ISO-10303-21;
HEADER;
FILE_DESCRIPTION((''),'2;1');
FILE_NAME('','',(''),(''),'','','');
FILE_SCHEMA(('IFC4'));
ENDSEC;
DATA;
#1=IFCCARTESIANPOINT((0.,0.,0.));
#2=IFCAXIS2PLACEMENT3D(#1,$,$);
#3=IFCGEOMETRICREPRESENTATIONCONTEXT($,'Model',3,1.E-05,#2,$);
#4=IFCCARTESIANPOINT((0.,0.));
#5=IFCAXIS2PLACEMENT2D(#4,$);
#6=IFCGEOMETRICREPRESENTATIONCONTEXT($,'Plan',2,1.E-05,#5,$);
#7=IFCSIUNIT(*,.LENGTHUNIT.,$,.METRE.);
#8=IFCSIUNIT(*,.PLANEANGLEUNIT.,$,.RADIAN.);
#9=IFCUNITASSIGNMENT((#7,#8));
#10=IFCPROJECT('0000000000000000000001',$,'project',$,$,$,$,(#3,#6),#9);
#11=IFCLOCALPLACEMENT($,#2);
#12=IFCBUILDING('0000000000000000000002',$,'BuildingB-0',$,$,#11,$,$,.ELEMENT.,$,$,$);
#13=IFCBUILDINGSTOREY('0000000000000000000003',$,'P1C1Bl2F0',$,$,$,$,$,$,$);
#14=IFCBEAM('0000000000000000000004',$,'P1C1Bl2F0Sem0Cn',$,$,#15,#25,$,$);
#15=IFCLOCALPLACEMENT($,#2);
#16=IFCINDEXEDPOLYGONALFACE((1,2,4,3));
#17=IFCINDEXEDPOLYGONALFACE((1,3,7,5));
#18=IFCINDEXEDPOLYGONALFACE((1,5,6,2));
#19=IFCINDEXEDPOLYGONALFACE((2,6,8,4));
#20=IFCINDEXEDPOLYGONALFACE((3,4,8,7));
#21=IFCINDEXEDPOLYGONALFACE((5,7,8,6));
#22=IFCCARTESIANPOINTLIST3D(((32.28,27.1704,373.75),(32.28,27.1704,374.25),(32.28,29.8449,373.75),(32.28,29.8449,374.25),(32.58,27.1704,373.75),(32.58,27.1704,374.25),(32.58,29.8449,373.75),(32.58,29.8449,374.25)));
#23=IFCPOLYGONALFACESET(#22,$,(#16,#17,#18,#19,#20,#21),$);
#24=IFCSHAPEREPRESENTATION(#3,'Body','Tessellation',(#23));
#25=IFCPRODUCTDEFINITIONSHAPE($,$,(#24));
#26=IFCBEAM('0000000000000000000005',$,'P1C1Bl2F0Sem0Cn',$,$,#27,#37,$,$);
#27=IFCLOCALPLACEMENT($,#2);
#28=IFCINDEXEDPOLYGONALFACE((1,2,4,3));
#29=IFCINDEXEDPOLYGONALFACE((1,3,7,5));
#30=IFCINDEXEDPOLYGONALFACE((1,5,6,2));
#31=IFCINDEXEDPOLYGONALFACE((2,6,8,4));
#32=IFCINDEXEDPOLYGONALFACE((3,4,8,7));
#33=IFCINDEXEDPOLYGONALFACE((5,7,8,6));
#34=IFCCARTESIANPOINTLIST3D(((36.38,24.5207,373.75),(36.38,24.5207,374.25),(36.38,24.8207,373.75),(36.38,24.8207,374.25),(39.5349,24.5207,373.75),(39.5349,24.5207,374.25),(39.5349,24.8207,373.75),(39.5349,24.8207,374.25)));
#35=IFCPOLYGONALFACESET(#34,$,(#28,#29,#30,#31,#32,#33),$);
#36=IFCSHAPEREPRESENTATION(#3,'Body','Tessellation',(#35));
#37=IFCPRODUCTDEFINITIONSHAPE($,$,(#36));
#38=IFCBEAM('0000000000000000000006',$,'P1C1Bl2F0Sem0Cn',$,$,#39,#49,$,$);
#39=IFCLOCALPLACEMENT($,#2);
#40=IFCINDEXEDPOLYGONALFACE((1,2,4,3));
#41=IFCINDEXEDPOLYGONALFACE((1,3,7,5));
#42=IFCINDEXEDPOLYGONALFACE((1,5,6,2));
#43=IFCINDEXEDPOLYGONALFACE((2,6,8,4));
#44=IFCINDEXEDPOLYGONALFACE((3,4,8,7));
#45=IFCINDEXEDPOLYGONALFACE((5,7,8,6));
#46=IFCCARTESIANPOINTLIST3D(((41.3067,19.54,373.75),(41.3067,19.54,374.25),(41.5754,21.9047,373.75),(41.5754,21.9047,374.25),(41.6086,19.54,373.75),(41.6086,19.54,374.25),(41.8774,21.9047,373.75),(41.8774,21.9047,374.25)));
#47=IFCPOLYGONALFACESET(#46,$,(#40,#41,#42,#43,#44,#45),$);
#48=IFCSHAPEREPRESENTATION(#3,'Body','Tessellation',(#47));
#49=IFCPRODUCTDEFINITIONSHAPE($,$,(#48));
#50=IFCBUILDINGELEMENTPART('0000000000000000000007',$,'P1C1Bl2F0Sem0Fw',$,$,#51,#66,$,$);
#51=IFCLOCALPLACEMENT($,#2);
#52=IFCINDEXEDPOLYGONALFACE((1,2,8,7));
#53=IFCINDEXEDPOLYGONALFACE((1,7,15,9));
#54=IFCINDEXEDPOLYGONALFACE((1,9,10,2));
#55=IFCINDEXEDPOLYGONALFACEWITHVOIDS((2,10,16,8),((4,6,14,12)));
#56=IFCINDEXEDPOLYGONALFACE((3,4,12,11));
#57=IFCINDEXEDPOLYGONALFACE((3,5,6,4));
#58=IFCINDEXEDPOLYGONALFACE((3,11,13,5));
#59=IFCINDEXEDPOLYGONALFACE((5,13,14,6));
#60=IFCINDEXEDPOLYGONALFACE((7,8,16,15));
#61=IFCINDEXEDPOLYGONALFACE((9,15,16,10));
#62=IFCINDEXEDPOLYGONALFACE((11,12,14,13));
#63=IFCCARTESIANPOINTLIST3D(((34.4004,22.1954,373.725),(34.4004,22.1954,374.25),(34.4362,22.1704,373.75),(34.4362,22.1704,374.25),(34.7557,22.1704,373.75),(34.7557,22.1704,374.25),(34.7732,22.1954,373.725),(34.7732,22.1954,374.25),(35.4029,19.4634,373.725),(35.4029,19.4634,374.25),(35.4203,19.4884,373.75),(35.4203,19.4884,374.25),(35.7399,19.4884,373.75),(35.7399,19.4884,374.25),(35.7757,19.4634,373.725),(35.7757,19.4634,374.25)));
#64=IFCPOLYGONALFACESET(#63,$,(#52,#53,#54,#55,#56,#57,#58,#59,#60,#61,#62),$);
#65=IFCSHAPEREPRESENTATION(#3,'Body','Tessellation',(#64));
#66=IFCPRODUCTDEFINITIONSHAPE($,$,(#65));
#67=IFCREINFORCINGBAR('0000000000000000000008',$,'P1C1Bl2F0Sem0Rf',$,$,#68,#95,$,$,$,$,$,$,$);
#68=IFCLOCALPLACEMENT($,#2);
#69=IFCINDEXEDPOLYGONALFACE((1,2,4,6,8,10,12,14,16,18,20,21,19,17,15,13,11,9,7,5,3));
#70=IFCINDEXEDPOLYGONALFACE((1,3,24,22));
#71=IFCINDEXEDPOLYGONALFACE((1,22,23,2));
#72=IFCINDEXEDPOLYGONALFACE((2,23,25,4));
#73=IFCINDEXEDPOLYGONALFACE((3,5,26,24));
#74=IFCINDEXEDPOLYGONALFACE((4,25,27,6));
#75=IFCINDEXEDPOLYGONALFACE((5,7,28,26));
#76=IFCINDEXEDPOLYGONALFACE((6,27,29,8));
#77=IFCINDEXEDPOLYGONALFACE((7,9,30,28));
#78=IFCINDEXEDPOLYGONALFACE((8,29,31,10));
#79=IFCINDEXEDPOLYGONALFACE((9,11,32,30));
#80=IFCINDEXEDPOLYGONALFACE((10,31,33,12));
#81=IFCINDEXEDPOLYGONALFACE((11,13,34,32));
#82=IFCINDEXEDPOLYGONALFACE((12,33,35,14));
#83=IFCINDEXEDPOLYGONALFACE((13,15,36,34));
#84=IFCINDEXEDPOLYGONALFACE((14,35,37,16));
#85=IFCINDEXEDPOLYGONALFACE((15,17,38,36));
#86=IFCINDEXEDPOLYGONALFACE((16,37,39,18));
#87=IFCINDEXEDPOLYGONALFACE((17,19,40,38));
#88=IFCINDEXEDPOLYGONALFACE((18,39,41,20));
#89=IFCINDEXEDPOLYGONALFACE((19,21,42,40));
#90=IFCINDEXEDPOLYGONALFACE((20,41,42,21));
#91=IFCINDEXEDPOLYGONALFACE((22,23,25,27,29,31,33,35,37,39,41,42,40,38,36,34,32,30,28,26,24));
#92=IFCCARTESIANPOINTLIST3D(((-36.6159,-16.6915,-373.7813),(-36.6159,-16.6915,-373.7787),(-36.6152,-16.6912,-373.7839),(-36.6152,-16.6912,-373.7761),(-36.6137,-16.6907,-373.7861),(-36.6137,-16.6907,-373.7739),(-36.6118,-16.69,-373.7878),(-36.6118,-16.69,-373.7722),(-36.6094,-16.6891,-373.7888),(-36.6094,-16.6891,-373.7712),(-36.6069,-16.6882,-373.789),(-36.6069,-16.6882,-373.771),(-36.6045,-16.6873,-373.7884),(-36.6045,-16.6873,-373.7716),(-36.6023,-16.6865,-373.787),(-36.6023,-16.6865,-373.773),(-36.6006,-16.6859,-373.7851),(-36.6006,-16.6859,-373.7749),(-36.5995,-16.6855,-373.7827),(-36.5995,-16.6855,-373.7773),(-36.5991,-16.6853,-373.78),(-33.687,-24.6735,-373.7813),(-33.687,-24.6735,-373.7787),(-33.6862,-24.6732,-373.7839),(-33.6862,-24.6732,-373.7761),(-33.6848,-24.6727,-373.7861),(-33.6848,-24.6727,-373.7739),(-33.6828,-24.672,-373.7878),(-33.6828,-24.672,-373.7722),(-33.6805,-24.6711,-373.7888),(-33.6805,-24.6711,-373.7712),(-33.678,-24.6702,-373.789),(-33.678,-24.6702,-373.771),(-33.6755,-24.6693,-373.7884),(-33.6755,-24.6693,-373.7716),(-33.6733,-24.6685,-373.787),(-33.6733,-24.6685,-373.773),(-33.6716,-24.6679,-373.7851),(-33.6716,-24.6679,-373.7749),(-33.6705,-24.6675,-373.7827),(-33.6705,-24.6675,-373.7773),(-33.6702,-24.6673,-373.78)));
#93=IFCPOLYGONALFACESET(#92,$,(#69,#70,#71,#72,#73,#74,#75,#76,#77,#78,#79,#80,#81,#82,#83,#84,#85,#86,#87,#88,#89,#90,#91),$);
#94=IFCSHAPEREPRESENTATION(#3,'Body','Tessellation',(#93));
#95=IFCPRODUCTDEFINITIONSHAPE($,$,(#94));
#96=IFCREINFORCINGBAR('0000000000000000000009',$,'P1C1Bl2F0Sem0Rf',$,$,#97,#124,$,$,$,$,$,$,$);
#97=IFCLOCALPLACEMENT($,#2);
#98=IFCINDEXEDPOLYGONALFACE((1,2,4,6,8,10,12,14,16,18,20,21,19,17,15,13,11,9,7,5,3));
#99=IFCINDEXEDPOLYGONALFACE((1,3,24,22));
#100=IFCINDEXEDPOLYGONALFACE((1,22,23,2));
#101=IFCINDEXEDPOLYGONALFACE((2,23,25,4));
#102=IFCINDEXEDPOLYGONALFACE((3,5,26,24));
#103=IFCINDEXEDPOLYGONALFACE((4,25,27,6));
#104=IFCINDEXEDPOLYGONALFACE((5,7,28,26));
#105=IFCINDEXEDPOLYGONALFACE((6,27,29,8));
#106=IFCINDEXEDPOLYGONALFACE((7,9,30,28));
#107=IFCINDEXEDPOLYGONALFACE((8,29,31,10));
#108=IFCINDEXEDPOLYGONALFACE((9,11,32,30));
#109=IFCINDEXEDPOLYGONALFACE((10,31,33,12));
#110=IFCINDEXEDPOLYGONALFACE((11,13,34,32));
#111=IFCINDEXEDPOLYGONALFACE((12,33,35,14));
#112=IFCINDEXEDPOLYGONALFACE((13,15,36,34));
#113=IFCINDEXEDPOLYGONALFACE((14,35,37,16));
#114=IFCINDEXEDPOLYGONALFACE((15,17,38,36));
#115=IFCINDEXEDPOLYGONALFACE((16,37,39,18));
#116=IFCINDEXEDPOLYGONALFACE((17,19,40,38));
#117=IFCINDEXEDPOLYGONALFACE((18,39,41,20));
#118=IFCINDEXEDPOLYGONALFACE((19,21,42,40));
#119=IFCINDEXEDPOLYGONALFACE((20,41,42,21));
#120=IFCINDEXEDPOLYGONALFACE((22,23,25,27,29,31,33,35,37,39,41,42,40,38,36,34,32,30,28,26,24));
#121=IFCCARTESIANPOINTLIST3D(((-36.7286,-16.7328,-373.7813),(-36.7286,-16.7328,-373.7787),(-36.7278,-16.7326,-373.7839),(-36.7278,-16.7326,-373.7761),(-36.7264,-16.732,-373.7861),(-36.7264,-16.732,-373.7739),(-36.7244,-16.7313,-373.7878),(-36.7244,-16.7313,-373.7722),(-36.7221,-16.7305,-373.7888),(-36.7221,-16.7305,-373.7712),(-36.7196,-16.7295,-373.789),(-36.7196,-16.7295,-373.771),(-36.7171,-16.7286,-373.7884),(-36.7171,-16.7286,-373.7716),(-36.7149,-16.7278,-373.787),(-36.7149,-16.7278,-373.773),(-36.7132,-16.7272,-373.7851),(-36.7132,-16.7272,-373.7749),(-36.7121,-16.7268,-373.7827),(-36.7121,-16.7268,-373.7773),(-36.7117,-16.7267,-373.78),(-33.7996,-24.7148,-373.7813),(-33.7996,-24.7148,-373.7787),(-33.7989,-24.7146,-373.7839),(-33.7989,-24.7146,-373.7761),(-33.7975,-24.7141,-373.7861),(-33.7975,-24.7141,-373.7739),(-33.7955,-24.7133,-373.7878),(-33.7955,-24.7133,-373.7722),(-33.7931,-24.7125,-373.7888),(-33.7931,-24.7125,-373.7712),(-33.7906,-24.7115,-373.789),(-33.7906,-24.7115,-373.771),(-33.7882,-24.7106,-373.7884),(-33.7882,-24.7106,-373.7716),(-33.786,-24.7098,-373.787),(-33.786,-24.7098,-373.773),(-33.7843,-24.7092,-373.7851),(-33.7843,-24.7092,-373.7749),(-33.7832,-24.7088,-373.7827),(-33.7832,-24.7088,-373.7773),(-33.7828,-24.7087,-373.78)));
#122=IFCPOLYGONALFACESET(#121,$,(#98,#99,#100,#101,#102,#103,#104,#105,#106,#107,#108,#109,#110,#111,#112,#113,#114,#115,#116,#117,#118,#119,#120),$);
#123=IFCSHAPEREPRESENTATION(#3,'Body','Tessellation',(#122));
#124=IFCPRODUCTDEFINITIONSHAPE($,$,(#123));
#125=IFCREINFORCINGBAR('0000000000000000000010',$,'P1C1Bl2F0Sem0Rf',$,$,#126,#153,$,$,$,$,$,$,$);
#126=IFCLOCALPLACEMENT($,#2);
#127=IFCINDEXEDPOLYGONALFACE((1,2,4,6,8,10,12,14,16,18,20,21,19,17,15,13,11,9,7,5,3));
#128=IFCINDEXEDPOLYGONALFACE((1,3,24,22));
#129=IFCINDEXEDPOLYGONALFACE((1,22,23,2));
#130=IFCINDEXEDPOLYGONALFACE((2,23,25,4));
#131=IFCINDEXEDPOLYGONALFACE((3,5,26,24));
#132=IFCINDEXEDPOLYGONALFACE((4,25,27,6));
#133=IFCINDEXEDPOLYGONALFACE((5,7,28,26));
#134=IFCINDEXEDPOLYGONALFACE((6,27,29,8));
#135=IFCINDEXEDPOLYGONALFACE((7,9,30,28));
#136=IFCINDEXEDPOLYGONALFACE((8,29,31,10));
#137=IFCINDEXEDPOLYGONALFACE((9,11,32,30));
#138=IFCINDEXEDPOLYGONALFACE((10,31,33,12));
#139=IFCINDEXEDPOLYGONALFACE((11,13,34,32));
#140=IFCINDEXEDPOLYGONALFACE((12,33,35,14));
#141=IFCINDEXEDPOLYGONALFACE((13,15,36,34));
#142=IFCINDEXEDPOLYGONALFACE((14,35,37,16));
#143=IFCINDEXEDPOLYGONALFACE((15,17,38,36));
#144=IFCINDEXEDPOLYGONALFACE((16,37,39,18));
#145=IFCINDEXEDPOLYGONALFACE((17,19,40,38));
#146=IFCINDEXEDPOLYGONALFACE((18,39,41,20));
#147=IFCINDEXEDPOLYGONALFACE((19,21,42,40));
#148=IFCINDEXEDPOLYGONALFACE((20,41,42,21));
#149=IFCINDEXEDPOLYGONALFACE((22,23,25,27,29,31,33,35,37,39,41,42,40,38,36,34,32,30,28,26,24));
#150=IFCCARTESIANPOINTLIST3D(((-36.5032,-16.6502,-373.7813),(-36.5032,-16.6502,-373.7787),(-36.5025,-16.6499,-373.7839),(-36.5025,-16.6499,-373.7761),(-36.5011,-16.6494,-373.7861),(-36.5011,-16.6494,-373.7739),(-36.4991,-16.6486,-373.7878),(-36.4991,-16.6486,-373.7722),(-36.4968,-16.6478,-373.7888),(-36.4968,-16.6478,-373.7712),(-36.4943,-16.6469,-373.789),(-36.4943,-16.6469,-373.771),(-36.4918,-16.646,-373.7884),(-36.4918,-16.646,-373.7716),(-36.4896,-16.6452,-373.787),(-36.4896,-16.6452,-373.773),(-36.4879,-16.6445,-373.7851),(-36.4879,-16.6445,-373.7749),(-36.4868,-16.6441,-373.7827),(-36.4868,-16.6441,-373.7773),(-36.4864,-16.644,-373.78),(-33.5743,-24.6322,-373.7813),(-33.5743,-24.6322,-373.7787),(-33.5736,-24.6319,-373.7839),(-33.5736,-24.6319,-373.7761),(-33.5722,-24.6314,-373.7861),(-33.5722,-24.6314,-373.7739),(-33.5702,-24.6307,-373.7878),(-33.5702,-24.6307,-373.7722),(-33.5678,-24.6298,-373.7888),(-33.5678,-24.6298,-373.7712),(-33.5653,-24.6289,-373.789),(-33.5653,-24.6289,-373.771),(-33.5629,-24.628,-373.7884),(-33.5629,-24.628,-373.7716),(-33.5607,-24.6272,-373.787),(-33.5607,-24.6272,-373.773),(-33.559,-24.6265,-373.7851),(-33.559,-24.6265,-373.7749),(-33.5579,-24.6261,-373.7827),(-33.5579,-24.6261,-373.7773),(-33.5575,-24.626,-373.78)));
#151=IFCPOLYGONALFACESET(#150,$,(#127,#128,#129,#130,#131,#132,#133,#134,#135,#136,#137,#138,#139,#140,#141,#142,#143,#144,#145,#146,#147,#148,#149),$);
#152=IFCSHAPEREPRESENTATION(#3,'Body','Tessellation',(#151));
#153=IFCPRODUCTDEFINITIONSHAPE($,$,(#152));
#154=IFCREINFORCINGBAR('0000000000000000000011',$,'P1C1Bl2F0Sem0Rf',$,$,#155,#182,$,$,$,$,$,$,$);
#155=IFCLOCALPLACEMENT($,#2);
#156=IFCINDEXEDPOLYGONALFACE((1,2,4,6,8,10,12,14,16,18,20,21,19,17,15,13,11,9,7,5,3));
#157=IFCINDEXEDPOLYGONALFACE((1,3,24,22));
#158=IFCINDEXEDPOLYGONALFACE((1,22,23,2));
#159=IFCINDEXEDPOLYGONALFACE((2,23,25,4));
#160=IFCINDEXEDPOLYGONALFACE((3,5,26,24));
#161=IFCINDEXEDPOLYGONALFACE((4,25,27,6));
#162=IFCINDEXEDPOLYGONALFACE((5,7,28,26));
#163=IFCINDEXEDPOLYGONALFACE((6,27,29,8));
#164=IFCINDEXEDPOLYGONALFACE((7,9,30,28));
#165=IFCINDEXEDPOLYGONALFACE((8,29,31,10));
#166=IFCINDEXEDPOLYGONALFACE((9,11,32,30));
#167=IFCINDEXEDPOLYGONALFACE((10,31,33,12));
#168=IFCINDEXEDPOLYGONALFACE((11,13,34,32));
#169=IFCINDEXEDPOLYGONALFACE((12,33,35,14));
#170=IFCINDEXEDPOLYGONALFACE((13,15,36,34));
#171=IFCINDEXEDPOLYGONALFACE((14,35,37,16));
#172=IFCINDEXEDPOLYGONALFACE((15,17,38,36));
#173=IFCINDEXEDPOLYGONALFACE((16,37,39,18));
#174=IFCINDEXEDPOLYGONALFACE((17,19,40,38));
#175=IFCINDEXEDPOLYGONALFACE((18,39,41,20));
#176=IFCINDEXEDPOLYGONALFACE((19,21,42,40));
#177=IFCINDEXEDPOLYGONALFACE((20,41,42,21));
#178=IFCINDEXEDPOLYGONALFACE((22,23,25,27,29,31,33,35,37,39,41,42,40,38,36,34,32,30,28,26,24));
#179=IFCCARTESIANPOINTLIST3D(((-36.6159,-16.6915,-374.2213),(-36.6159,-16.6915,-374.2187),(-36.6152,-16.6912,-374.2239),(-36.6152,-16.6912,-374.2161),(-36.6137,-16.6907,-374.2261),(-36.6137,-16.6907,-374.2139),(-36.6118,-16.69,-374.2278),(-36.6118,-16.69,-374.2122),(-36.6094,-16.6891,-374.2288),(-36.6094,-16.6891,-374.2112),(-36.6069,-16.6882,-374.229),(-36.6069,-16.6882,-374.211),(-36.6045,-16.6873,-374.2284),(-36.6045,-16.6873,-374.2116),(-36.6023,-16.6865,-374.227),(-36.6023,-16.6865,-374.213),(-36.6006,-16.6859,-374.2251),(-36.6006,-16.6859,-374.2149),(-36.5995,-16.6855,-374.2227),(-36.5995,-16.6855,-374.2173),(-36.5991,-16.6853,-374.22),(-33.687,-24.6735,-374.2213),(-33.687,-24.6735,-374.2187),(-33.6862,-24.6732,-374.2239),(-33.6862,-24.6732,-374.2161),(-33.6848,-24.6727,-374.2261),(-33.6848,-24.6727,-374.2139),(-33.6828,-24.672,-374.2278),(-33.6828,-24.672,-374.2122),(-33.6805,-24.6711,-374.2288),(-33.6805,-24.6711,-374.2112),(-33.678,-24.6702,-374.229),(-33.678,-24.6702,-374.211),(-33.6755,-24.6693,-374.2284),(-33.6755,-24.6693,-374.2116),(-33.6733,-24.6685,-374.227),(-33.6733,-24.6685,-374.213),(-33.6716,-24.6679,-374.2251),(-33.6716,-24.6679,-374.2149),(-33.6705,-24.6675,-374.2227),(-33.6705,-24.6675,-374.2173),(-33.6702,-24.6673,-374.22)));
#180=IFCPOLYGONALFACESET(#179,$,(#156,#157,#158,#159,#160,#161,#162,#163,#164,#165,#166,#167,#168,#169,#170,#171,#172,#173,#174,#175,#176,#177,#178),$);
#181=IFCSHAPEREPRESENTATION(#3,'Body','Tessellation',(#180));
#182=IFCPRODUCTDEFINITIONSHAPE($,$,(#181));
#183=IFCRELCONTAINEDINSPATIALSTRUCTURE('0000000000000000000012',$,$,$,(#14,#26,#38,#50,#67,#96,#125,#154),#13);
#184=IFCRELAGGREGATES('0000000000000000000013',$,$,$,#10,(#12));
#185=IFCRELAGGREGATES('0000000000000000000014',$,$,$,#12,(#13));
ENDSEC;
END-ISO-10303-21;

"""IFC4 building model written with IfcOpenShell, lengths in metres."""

from ifc_helpers import new_model, entity, si_unit, origin, origin_2d, place, context, project, spatial, polyline, outline, extrude, element, save


model = new_model("IFC4")

# Units and contexts
model_context = context("Model", 3, precision=1e-05, world=origin())
plan_context = context("Plan", 2, precision=1e-05, world=origin_2d())
ifc_project = project(units=[si_unit("LENGTHUNIT", "METRE"), si_unit("PLANEANGLEUNIT", "RADIAN")], contexts=[model_context, plan_context])

# Building, storey
building_placement = place(None, origin())
building = spatial("IfcBuilding", under=ifc_project, at=building_placement, Name="BuildingB-0", CompositionType="ELEMENT")
storey = spatial("IfcBuildingStorey", under=building, Name="P1C1Bl2F0")

# Beams
element("IfcBeam", 1, inside=storey, Name="P1C1Bl2F0Sem0Cn", context=model_context, shape_type="SweptSolid", body=[
    extrude(outline(polyline([(32.28, 27.1704, 373.75), (32.58, 27.1704, 373.75), (32.58, 29.8449, 373.75), (32.28, 29.8449, 373.75), (32.28, 27.1704, 373.75)])), None, (0.0, 0.0, 1.0), 0.5),
])
element("IfcBeam", 2, inside=storey, Name="P1C1Bl2F0Sem0Cn", context=model_context, shape_type="SweptSolid", body=[
    extrude(outline(polyline([(36.38, 24.5207, 373.75), (36.38, 24.8207, 373.75), (39.5349, 24.8207, 373.75), (39.5349, 24.5207, 373.75), (36.38, 24.5207, 373.75)])), None, (0.0, 0.0, 1.0), 0.5),
])
element("IfcBeam", 3, inside=storey, Name="P1C1Bl2F0Sem0Cn", context=model_context, shape_type="SweptSolid", body=[
    extrude(outline(polyline([(41.3067, 19.54, 373.75), (41.6086, 19.54, 373.75), (41.8774, 21.9047, 373.75), (41.5754, 21.9047, 373.75), (41.3067, 19.54, 373.75)])), None, (0.0, 0.0, 1.0), 0.5),
])

# Building element part, opening
building_element_part_1 = element("IfcBuildingElementPart", 4, inside=storey, Name="P1C1Bl2F0Sem0Fw", context=model_context, shape_type="SweptSolid", body=[
    extrude(outline(polyline([(35.4029, 19.4634, 373.725), (35.7757, 19.4634, 373.725), (34.7732, 22.1954, 373.725), (34.4004, 22.1954, 373.725), (35.4029, 19.4634, 373.725)])), None, (0.0, 0.0, 1.0), 0.525),
])
element("IfcOpeningElement", 5, inside=storey, cuts=building_element_part_1, context=model_context, shape_type="SweptSolid", body=[
    extrude(outline(polyline([(35.4203, 19.4884, 373.75), (35.7399, 19.4884, 373.75), (34.7557, 22.1704, 373.75), (34.4362, 22.1704, 373.75), (35.4203, 19.4884, 373.75)])), None, (0.0, 0.0, 1.0), 0.5),
])

# Reinforcing bars
element("IfcReinforcingBar", 6, inside=storey, Name="P1C1Bl2F0Sem0Rf", context=model_context, shape_type="SweptSolid", body=[
    entity("IfcSurfaceCurveSweptAreaSolid", entity("IfcCircleProfileDef", "AREA", None, None, 0.009), None, entity("IfcPolyline", [entity("IfcCartesianPoint", [36.6075, 16.6884, 373.78]), entity("IfcCartesianPoint", [33.6786, 24.6704, 373.78])]), None, None, entity("IfcPlane", entity("IfcAxis2Placement3D", entity("IfcCartesianPoint", [36.6075, 16.6884, 373.78]), entity("IfcDirection", [0.0, 0.0, 1.0]), entity("IfcDirection", [1.0, 0.0, 0.0])))),
])
element("IfcReinforcingBar", 7, inside=storey, Name="P1C1Bl2F0Sem0Rf", context=model_context, shape_type="SweptSolid", body=[
    entity("IfcSurfaceCurveSweptAreaSolid", entity("IfcCircleProfileDef", "AREA", None, None, 0.009), None, entity("IfcPolyline", [entity("IfcCartesianPoint", [36.7202, 16.7298, 373.78]), entity("IfcCartesianPoint", [33.7913, 24.7118, 373.78])]), None, None, entity("IfcPlane", entity("IfcAxis2Placement3D", entity("IfcCartesianPoint", [36.7202, 16.7298, 373.78]), entity("IfcDirection", [0.0, 0.0, 1.0]), entity("IfcDirection", [1.0, 0.0, 0.0])))),
])
element("IfcReinforcingBar", 8, inside=storey, Name="P1C1Bl2F0Sem0Rf", context=model_context, shape_type="SweptSolid", body=[
    entity("IfcSurfaceCurveSweptAreaSolid", entity("IfcCircleProfileDef", "AREA", None, None, 0.009), None, entity("IfcPolyline", [entity("IfcCartesianPoint", [36.4949, 16.6471, 373.78]), entity("IfcCartesianPoint", [33.566, 24.6291, 373.78])]), None, None, entity("IfcPlane", entity("IfcAxis2Placement3D", entity("IfcCartesianPoint", [36.4949, 16.6471, 373.78]), entity("IfcDirection", [0.0, 0.0, 1.0]), entity("IfcDirection", [1.0, 0.0, 0.0])))),
])
element("IfcReinforcingBar", 9, inside=storey, Name="P1C1Bl2F0Sem0Rf", context=model_context, shape_type="SweptSolid", body=[
    entity("IfcSurfaceCurveSweptAreaSolid", entity("IfcCircleProfileDef", "AREA", None, None, 0.009), None, entity("IfcPolyline", [entity("IfcCartesianPoint", [36.6075, 16.6884, 374.22]), entity("IfcCartesianPoint", [33.6786, 24.6704, 374.22])]), None, None, entity("IfcPlane", entity("IfcAxis2Placement3D", entity("IfcCartesianPoint", [36.6075, 16.6884, 374.22]), entity("IfcDirection", [0.0, 0.0, 1.0]), entity("IfcDirection", [1.0, 0.0, 0.0])))),
])

save(model, "model.ifc")
